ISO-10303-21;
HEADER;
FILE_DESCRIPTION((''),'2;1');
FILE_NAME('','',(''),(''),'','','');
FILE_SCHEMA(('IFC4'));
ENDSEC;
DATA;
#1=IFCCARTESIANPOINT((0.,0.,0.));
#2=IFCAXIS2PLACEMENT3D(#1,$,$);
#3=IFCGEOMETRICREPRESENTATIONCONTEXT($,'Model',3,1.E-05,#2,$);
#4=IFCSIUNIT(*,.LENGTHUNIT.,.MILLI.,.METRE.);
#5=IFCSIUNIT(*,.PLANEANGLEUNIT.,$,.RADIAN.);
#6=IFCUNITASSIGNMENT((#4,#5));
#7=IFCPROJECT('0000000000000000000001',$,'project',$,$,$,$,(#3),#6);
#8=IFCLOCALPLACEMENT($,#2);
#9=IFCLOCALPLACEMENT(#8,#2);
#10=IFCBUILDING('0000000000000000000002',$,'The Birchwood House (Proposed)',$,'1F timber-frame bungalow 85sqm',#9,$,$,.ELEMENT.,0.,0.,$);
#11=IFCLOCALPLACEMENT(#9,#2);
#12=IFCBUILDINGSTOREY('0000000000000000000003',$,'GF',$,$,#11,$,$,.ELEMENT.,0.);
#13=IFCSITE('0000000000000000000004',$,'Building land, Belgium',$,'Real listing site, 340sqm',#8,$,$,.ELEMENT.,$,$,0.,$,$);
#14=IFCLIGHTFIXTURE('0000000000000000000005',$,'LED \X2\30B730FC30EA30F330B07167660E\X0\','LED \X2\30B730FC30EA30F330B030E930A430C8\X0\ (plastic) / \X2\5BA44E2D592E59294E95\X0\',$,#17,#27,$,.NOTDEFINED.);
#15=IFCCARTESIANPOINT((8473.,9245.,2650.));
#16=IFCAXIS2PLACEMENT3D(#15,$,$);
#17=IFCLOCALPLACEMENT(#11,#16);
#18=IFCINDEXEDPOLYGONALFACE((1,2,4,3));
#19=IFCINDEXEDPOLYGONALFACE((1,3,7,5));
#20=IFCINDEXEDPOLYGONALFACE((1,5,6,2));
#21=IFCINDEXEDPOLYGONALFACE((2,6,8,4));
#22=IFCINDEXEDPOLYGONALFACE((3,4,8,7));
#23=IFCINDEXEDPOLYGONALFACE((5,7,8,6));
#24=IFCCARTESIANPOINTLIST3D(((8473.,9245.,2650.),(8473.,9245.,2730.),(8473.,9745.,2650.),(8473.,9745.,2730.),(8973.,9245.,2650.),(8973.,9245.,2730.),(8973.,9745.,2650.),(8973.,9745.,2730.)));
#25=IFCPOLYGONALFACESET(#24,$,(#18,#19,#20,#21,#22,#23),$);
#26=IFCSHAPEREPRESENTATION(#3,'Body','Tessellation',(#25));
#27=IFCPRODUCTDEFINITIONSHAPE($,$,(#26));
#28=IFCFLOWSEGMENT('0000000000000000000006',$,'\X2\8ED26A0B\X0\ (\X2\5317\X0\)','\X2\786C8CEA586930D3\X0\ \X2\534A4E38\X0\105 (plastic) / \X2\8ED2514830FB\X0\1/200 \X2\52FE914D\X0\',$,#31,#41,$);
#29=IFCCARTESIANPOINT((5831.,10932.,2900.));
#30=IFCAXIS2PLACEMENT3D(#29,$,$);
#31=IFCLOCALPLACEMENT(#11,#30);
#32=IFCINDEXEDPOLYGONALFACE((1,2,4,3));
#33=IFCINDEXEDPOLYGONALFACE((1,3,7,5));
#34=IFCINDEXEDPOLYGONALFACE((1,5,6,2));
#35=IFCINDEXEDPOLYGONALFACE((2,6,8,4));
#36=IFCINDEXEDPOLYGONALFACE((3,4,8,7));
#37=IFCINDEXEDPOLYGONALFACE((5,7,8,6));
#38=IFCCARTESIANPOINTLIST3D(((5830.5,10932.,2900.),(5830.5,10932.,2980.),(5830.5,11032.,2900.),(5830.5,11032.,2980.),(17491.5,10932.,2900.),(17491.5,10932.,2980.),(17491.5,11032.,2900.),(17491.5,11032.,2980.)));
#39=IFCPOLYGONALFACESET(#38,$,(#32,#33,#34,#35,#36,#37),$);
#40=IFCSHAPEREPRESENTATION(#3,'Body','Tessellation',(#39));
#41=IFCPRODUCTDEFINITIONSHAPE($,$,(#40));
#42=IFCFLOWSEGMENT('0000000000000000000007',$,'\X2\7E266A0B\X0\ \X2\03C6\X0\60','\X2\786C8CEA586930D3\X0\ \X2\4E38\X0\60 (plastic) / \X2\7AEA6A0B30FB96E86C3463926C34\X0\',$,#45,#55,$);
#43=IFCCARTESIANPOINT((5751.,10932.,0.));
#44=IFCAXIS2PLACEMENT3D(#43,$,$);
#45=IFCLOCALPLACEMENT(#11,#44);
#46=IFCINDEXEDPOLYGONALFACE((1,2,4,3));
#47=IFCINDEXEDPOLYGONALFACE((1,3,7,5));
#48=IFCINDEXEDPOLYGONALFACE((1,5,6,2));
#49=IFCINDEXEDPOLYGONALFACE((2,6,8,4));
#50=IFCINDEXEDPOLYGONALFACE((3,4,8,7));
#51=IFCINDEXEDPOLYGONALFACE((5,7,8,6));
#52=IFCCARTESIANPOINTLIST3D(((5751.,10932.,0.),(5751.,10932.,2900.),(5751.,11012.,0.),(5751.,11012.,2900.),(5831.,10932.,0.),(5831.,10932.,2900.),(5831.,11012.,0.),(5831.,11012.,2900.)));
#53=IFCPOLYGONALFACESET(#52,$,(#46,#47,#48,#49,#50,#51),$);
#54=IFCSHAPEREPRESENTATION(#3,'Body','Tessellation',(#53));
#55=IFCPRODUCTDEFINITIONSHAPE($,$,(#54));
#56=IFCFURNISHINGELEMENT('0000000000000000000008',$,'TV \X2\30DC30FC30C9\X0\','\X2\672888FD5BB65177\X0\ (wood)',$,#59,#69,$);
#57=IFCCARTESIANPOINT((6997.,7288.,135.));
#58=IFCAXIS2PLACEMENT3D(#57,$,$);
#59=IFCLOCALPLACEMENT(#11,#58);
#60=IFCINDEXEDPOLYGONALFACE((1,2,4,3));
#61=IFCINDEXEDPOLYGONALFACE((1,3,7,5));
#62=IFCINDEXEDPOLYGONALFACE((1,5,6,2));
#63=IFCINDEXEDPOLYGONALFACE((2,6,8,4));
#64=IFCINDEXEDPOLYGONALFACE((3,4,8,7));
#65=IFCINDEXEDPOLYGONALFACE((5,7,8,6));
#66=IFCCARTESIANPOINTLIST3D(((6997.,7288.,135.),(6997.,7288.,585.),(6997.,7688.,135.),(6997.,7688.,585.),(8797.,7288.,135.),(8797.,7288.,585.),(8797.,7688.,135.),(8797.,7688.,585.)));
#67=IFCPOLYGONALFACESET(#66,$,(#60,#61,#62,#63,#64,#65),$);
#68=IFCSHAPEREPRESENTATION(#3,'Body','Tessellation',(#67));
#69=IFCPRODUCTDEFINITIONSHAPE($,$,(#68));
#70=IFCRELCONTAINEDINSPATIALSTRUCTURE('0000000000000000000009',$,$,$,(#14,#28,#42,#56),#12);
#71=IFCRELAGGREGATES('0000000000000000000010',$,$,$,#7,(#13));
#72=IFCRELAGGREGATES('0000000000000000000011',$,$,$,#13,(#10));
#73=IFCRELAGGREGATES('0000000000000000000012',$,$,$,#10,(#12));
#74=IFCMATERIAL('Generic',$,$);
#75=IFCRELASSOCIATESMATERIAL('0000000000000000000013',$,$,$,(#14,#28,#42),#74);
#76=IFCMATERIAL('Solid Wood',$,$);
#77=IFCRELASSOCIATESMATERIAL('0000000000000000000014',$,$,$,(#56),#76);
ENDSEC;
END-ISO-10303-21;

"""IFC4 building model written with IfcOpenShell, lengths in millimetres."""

from ifc_helpers import new_model, si_unit, frame, frame_2d, origin, place, context, project, spatial, rectangle, extrude, material, element, save


model = new_model("IFC4")

# Units and contexts
model_context = context("Model", 3, precision=1e-05, world=origin())
ifc_project = project(units=[si_unit("LENGTHUNIT", "METRE", prefix="MILLI"), si_unit("PLANEANGLEUNIT", "RADIAN")], contexts=[model_context])

# Site, building, storey
site_placement = place(None, origin())
site = spatial("IfcSite", under=ifc_project, at=site_placement, Name="Building land, Belgium", ObjectType="Real listing site, 340sqm", CompositionType="ELEMENT", RefElevation=0.0)
building_placement = place(site_placement, origin())
building = spatial("IfcBuilding", under=site, at=building_placement, Name="The Birchwood House (Proposed)", ObjectType="1F timber-frame bungalow 85sqm", CompositionType="ELEMENT", ElevationOfRefHeight=0.0, ElevationOfTerrain=0.0)
storey_placement = place(building_placement, origin())
storey = spatial("IfcBuildingStorey", under=building, at=storey_placement, Name="GF", CompositionType="ELEMENT", Elevation=0.0)

# Shared definitions
ifc_material_1 = material(Name="Solid Wood")

# Shared definitions
ifc_material_2 = material(Name="Generic")

# Light fixture
light_fixture_placement = place(storey_placement, frame((8473.0, 9245.0, 2650.0)))
element("IfcLightFixture", 1, at=light_fixture_placement, inside=storey, material=ifc_material_2, Name="LED シーリング照明", Description="LED シーリングライト (plastic) / 室中央天井", PredefinedType="NOTDEFINED", context=model_context, shape_type="SweptSolid", body=[
    extrude(rectangle(XDim=500.0, YDim=500.0, at=frame_2d((250.0, 250.0))), frame((8473.0, 9245.0, 2650.0)), (0.0, 0.0, 1.0), 80.0),
])

# Flow segments
flow_segment_1_placement = place(storey_placement, frame((5831.0, 10932.0, 2900.0)))
element("IfcFlowSegment", 2, at=flow_segment_1_placement, inside=storey, material=ifc_material_2, Name="軒樋 (北)", Description="硬質塩ビ 半丸105 (plastic) / 軒先・1/200 勾配", context=model_context, shape_type="SweptSolid", body=[
    extrude(rectangle(XDim=11661.0, YDim=100.0, at=frame_2d((5830.0, 50.0))), frame((5831.0, 10932.0, 2900.0)), (0.0, 0.0, 1.0), 80.0),
])
flow_segment_2_placement = place(storey_placement, frame((5751.0, 10932.0, 0.0)))
element("IfcFlowSegment", 3, at=flow_segment_2_placement, inside=storey, material=ifc_material_2, Name="縦樋 φ60", Description="硬質塩ビ 丸60 (plastic) / 竪樋・雨水排水", context=model_context, shape_type="SweptSolid", body=[
    extrude(rectangle(XDim=80.0, YDim=80.0, at=frame_2d((40.0, 40.0))), frame((5751.0, 10932.0, 0.0)), (0.0, 0.0, 1.0), 2900.0),
])

# Furnishing element
furnishing_placement = place(storey_placement, frame((6997.0, 7288.0, 135.0)))
element("IfcFurnishingElement", 4, at=furnishing_placement, inside=storey, material=ifc_material_1, Name="TV ボード", Description="木製家具 (wood)", context=model_context, shape_type="SweptSolid", body=[
    extrude(rectangle(XDim=1800.0, YDim=400.0, at=frame_2d((900.0, 200.0))), frame((6997.0, 7288.0, 135.0)), (0.0, 0.0, 1.0), 450.0),
])

save(model, "model.ifc")
